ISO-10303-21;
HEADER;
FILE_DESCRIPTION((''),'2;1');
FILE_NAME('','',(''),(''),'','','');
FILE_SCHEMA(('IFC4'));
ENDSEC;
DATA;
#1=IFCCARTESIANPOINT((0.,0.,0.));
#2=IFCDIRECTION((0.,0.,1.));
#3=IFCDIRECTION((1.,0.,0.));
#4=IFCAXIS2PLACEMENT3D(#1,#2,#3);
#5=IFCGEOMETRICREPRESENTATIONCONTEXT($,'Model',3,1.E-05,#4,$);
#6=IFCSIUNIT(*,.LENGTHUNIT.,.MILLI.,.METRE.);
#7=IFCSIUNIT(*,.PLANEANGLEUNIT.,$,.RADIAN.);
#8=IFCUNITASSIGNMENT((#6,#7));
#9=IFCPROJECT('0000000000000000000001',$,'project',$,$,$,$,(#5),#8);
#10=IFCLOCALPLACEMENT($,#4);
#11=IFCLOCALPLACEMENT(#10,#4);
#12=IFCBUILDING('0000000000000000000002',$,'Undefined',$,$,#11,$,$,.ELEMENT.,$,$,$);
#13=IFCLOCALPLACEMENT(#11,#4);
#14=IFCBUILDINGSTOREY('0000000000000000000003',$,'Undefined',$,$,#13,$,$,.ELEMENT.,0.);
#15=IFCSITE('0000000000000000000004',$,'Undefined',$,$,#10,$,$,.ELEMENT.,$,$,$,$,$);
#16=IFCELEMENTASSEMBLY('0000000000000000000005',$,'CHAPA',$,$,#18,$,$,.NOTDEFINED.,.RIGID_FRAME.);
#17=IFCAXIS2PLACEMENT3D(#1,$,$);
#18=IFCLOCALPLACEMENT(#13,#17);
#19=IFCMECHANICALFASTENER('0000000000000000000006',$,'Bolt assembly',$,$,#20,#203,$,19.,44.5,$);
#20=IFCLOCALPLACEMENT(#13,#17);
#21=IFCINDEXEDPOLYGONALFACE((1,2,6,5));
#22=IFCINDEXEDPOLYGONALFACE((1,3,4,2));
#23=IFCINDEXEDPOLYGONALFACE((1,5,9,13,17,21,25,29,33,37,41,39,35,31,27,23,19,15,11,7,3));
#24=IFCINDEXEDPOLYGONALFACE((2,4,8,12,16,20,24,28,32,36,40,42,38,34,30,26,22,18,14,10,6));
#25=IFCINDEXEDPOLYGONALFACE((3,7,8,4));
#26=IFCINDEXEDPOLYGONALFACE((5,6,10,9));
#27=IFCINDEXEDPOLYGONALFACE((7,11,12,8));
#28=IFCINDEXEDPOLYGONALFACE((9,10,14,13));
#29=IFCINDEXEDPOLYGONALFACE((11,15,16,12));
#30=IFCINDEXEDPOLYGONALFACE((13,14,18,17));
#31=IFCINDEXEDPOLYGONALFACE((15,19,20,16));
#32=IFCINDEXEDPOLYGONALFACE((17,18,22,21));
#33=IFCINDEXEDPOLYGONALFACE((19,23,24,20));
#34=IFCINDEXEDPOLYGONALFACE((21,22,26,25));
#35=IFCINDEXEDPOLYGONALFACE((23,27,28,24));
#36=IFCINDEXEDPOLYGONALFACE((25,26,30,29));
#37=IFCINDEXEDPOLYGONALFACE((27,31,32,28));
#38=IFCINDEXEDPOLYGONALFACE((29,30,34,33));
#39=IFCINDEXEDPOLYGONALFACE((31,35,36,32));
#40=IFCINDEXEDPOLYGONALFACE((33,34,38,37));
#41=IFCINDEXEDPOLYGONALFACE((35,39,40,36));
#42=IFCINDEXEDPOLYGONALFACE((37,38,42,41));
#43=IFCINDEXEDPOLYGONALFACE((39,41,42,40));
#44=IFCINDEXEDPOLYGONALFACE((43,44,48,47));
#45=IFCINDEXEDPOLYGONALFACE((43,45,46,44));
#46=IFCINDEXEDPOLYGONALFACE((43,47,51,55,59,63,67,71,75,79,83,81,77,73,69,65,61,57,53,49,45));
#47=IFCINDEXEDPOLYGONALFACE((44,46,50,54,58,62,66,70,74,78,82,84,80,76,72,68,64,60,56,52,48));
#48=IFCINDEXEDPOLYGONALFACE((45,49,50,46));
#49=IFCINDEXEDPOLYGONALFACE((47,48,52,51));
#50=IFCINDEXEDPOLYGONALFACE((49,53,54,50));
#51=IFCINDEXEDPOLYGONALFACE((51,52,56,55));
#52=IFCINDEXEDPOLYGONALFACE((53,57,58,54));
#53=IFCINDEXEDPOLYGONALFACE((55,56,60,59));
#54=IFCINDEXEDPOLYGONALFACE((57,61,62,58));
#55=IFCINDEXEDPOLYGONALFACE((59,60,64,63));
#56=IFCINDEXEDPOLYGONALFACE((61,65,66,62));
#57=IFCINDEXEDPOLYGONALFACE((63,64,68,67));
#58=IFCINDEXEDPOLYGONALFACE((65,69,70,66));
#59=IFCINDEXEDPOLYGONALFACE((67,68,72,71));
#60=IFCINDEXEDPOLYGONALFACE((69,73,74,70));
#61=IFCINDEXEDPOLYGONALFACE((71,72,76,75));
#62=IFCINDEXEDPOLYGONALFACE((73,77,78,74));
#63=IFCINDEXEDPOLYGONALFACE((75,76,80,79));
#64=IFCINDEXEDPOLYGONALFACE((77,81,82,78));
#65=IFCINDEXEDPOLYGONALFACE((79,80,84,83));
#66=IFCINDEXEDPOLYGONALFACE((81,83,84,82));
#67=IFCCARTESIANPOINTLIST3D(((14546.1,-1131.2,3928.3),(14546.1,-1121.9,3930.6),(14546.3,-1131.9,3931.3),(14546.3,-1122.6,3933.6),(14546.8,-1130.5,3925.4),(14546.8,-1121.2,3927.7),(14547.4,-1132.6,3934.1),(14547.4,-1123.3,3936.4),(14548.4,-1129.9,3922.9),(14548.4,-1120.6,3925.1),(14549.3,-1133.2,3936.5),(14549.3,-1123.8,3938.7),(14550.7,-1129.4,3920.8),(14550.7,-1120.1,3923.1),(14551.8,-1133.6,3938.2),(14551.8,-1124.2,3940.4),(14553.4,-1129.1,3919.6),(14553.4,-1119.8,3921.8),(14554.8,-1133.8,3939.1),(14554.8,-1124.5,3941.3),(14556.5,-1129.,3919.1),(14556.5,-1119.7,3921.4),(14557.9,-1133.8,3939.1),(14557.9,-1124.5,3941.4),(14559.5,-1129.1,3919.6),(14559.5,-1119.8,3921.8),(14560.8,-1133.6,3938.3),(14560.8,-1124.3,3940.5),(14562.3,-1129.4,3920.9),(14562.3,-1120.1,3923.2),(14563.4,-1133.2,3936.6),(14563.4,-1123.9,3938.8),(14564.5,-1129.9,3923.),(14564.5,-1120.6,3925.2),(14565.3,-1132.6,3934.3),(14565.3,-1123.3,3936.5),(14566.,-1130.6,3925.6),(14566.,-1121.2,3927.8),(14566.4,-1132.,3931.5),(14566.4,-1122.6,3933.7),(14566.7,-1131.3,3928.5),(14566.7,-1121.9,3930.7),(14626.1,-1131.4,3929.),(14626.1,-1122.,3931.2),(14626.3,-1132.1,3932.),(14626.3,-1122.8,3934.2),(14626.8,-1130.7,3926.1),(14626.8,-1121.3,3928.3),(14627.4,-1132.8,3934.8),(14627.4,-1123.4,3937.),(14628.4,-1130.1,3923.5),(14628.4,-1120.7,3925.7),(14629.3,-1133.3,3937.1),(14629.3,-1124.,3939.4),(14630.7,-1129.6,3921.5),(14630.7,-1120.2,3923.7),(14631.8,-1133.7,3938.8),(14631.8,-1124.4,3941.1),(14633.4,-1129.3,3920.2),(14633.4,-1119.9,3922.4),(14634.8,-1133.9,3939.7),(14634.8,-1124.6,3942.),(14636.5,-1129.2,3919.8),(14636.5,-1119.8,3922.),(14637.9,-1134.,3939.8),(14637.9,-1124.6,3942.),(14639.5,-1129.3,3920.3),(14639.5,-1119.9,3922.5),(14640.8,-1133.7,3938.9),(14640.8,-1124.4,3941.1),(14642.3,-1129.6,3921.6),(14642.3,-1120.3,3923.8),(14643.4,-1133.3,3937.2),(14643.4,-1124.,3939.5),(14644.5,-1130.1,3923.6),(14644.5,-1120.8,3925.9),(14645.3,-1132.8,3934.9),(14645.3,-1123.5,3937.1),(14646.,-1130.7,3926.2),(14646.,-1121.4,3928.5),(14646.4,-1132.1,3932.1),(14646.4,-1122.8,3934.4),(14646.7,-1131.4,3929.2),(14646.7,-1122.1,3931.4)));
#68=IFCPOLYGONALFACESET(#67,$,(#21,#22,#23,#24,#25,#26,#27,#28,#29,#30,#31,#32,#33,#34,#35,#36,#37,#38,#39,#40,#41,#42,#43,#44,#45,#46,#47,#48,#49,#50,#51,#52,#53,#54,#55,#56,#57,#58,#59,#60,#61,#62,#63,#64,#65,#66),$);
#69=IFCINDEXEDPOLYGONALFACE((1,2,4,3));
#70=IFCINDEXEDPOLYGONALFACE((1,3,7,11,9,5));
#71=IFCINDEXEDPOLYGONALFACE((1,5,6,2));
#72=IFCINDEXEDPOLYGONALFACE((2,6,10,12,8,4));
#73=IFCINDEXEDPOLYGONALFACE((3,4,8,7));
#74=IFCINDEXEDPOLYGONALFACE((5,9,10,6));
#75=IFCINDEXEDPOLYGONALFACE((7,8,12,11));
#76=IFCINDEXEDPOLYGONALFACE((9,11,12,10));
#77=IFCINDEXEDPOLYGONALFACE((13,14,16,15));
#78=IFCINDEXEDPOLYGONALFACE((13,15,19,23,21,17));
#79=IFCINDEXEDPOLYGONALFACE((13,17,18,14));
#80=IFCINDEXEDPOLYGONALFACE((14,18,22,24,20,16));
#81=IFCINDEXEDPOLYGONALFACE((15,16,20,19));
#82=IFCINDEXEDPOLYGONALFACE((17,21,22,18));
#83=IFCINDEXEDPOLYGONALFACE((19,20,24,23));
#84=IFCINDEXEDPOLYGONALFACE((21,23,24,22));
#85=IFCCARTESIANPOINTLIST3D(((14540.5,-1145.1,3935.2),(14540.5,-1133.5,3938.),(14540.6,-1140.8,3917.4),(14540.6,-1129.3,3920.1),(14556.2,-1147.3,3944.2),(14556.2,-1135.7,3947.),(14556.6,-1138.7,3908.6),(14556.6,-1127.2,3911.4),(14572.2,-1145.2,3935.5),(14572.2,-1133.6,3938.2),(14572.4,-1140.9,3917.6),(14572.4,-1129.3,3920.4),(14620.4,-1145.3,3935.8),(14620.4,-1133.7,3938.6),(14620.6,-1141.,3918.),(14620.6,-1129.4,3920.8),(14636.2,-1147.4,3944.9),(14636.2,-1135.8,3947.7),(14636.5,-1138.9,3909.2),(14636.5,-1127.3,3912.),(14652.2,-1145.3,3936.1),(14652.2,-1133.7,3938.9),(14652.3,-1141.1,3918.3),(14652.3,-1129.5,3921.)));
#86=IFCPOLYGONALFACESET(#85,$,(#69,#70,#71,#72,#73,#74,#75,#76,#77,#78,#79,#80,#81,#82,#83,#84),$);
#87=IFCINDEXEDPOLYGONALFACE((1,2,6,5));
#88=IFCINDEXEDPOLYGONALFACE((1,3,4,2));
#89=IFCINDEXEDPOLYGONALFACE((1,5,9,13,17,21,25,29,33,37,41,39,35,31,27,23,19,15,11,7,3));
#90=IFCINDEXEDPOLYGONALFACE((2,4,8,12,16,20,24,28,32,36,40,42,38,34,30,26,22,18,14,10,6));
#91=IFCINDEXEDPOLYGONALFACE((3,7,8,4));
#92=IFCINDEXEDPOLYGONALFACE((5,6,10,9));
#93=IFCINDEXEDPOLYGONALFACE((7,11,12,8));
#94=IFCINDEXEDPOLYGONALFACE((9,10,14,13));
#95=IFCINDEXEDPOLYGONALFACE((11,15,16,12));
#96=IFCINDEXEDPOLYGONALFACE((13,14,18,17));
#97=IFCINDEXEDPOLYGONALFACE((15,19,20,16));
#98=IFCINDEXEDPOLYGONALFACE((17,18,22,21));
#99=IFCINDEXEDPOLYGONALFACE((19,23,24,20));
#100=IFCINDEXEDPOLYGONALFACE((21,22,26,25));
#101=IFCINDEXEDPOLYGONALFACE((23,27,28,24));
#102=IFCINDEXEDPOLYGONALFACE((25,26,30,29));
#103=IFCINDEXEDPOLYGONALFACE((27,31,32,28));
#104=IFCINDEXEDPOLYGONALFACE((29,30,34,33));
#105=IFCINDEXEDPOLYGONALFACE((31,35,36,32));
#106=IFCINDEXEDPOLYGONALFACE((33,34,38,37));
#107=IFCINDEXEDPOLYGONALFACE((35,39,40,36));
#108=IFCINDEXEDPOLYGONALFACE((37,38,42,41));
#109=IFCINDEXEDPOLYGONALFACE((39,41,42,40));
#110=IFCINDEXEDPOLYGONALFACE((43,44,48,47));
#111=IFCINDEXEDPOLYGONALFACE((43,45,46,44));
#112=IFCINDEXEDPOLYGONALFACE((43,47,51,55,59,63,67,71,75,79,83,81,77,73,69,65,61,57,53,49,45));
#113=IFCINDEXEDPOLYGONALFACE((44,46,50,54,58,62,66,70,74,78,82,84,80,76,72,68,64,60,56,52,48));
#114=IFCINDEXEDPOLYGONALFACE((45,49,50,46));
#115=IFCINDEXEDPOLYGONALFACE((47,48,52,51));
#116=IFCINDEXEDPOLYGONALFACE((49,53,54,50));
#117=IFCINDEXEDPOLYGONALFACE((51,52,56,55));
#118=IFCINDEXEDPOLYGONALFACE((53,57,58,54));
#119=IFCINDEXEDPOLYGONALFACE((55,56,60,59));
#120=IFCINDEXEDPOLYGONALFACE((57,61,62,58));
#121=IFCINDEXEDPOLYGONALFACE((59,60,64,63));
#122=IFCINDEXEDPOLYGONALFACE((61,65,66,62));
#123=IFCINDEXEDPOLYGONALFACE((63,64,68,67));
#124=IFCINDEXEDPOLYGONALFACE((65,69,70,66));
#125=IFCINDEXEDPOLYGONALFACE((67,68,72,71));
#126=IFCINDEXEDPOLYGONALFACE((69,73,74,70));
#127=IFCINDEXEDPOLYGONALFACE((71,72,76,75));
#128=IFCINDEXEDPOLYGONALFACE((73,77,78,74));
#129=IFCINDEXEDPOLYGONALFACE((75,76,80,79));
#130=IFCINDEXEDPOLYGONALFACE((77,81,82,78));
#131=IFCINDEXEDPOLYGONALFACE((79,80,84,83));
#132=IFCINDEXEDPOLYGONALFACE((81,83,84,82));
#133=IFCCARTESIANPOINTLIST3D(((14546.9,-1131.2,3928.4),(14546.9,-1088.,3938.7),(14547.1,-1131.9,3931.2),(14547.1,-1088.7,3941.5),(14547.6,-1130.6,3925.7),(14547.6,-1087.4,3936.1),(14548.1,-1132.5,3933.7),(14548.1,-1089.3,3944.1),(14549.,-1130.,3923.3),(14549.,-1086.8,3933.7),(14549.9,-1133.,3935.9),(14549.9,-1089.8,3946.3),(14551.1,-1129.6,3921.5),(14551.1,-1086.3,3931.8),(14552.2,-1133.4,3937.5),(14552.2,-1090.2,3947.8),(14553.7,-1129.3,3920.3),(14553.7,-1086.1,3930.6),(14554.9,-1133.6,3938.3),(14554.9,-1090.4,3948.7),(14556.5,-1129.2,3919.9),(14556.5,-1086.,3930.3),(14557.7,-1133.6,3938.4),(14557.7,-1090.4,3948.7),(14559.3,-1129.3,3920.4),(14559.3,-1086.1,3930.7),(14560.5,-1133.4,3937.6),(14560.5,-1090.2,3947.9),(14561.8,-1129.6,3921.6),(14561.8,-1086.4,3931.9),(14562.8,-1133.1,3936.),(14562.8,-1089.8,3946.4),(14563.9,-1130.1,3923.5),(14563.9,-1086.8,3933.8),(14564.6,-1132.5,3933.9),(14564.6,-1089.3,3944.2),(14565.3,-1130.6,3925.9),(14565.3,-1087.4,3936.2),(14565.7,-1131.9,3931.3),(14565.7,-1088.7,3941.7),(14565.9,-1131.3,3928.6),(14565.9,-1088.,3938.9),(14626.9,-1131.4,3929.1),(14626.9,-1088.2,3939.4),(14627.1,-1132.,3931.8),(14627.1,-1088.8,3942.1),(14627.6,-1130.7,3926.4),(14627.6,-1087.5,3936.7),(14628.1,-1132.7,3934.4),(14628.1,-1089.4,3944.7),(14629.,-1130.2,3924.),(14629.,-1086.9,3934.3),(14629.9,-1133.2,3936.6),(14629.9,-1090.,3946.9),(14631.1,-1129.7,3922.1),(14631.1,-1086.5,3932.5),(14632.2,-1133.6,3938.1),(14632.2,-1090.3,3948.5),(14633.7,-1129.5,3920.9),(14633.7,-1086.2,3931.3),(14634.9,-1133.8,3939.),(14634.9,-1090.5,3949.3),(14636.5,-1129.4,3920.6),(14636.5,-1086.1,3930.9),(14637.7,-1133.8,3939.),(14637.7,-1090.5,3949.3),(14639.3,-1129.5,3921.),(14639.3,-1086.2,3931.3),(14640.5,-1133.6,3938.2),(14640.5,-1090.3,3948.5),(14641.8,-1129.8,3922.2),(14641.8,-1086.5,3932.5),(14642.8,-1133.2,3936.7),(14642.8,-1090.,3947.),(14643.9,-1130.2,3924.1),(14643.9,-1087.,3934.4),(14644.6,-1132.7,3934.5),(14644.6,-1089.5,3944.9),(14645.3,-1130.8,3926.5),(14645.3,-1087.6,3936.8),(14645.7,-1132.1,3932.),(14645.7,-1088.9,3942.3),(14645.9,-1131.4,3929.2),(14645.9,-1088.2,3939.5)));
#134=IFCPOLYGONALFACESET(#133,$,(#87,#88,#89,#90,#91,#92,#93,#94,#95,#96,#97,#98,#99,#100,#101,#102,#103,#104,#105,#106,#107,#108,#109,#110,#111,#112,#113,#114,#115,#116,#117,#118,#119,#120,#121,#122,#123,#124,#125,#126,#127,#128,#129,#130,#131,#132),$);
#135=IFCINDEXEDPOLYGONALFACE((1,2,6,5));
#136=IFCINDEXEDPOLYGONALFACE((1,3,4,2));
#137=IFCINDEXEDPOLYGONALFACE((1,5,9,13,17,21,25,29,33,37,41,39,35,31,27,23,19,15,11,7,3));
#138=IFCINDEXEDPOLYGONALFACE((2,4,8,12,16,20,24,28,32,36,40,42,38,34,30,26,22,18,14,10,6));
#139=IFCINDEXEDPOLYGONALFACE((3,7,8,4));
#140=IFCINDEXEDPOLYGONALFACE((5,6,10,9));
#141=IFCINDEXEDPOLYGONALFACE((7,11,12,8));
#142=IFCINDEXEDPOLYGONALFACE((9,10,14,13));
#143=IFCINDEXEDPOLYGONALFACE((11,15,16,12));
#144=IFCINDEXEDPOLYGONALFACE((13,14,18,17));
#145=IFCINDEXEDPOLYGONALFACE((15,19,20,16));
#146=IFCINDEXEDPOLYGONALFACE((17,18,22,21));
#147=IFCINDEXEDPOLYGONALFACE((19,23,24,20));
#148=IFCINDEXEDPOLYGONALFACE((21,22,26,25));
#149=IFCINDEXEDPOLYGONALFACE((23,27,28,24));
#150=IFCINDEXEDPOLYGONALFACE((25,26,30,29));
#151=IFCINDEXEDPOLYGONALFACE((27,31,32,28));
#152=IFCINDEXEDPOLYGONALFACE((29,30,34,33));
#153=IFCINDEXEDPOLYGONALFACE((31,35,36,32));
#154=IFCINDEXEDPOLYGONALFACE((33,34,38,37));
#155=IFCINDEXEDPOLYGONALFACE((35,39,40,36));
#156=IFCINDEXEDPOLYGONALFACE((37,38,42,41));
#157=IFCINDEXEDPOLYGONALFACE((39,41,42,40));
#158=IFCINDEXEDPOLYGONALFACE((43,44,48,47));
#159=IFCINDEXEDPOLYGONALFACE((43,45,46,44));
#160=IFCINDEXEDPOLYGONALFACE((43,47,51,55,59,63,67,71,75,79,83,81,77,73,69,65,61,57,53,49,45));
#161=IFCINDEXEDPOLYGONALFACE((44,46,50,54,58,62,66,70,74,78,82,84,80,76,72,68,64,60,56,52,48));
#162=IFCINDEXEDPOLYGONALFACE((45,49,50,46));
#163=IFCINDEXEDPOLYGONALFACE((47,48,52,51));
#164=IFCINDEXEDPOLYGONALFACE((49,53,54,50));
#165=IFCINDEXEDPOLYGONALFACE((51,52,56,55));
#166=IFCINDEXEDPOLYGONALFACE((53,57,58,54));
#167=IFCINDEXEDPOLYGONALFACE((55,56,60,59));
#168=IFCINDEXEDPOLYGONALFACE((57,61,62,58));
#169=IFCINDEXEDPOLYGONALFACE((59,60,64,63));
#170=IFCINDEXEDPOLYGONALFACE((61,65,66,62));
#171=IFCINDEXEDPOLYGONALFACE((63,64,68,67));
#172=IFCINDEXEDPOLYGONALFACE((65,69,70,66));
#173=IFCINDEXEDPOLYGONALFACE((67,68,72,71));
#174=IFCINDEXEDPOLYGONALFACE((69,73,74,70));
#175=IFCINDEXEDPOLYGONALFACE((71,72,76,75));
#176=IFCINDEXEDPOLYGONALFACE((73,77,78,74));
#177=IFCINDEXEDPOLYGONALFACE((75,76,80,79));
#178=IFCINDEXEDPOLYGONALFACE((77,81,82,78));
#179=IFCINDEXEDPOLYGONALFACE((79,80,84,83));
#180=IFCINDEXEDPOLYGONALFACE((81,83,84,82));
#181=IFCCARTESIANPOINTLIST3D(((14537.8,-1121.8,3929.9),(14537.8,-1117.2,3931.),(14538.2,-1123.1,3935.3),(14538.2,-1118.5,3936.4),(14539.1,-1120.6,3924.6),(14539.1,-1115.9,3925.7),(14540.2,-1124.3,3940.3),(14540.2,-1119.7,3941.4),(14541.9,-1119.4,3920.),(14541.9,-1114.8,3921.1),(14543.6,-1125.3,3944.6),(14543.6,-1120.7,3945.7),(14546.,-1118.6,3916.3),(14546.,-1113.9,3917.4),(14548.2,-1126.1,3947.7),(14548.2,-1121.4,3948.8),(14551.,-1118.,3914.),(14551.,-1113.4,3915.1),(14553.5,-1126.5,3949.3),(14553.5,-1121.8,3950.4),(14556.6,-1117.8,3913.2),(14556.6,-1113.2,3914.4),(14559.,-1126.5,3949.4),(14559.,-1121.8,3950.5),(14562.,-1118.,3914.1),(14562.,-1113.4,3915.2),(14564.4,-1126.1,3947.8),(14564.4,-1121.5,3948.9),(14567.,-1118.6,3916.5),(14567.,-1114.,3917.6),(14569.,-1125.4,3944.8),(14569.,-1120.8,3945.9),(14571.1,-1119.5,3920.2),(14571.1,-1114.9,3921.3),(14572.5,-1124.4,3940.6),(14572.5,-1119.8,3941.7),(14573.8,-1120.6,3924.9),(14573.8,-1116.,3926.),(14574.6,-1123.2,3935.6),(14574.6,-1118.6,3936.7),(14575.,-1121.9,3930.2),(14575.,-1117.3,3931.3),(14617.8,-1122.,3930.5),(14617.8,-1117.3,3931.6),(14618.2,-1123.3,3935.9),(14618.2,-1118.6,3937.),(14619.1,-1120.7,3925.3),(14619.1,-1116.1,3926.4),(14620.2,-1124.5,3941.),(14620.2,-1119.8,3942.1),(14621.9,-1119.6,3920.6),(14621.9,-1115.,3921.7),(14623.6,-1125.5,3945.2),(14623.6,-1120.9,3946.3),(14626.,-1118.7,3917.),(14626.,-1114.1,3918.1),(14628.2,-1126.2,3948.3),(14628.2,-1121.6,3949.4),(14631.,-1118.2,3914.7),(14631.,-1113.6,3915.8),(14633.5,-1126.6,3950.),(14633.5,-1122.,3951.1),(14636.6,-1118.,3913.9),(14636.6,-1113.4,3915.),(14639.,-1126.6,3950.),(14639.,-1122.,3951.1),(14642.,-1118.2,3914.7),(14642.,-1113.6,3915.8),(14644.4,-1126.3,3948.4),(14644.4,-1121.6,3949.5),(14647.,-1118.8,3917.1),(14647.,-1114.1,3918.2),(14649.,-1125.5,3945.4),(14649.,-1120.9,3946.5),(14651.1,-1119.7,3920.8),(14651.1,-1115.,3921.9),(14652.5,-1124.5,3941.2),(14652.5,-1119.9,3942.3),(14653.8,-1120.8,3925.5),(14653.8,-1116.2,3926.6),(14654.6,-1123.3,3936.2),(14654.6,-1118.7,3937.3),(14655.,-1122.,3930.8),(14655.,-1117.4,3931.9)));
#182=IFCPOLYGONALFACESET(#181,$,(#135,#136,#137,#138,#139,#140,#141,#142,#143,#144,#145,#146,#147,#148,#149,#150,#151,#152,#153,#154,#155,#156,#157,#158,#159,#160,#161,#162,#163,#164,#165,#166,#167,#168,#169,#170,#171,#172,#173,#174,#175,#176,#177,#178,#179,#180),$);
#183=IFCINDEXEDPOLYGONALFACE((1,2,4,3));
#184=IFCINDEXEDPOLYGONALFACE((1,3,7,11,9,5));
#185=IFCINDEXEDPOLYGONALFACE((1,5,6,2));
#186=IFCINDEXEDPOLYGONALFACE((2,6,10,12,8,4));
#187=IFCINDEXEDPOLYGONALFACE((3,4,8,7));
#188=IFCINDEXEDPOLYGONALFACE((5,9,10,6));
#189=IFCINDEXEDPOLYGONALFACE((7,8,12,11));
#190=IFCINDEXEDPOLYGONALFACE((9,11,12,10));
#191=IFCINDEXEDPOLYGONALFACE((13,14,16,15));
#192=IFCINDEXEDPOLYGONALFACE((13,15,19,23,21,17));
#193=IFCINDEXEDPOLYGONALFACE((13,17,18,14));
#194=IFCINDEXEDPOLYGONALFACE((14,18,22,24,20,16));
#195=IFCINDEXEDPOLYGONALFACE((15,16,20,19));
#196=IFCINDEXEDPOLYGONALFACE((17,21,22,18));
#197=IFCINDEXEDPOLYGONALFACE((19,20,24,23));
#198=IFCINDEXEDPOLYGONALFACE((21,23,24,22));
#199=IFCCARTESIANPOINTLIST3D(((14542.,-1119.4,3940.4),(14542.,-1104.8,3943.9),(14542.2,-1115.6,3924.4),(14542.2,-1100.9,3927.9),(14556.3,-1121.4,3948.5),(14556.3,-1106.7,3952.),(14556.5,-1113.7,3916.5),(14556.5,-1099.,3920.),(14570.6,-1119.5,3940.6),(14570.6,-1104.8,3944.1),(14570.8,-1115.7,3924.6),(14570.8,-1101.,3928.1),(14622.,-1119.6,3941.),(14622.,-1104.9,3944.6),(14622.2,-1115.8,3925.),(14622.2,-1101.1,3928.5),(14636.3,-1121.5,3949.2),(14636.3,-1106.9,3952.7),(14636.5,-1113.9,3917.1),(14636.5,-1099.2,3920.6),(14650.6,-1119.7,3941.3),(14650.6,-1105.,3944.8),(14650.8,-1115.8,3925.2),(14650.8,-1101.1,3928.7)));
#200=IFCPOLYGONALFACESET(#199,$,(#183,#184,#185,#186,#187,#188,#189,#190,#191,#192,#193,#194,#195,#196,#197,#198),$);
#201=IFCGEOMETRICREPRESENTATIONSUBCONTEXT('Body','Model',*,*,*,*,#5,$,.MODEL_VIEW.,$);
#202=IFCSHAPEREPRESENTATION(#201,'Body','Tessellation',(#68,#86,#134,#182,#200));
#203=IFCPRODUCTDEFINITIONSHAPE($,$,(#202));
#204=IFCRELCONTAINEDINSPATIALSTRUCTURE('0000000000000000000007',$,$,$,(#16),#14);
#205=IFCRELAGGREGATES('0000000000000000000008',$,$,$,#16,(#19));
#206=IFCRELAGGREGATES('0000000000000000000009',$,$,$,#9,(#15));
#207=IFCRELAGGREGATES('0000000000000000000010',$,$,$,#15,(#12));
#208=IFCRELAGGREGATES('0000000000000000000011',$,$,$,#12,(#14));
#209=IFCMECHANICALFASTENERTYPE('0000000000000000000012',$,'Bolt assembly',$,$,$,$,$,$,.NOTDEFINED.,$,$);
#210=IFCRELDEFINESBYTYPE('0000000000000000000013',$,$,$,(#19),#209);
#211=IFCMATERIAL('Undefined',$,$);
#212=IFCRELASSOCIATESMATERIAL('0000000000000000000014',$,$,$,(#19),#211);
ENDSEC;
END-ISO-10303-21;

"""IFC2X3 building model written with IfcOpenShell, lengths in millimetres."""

from ifc_helpers import new_model, si_unit, frame, origin_with_axes, origin_2d_with_axis, place, context, subcontext, project, spatial, polyline, circle, outline, extrude, source, transform, mapped, material, type_object, element, aggregate, save


model = new_model("IFC2X3")

# Units and contexts
model_context = context("Model", 3, precision=1e-05, world=origin_with_axes())
body_context = subcontext(model_context, "Body", "Model", "MODEL_VIEW")
ifc_project = project(units=[si_unit("LENGTHUNIT", "METRE", prefix="MILLI"), si_unit("PLANEANGLEUNIT", "RADIAN")], contexts=[model_context])

# Site, building, storey
site_placement = place(None, origin_with_axes())
site = spatial("IfcSite", under=ifc_project, at=site_placement, Name="Undefined", CompositionType="ELEMENT")
building_placement = place(site_placement, origin_with_axes())
building = spatial("IfcBuilding", under=site, at=building_placement, Name="Undefined", CompositionType="ELEMENT")
storey_placement = place(building_placement, origin_with_axes())
storey = spatial("IfcBuildingStorey", under=building, at=storey_placement, Name="Undefined", CompositionType="ELEMENT", Elevation=0.0)

# Element assembly
assembly_1_placement = place(storey_placement, origin_with_axes())
assembly_1 = element("IfcElementAssembly", 1, at=assembly_1_placement, inside=storey, Name="CHAPA", AssemblyPlace="NOTDEFINED", PredefinedType="RIGID_FRAME")

# Shared definitions
ifc_material_1 = material(Name="Undefined")
mechanical_fastener_type = type_object("IfcMechanicalFastenerType", Name="Bolt assembly")

# Mechanical fastener
shared_shape_1 = source(origin_with_axes(), body_context, "Body", "SweptSolid", [
    extrude(circle(Radius=10.3, at=origin_2d_with_axis()), frame((0.0, 0.0, 0.0), z_axis=(0.0, 1.0, 0.0), x_axis=(1.0, 0.0, 0.0)), (0.0, 0.0, 1.0), 9.6),
    extrude(outline(polyline([(18.3, 0.0), (9.2, 15.9), (-9.2, 15.9), (-18.3, 0.0), (-9.2, -15.9), (9.2, -15.9), (18.3, 0.0)])), frame((0.0, -11.9, 0.0), z_axis=(0.0, 1.0, 0.0), x_axis=(1.0, 0.0, 0.0)), (0.0, 0.0, 1.0), 11.9),
    extrude(circle(Radius=9.5, at=origin_2d_with_axis()), frame((0.0, 0.0, 0.0), z_axis=(0.0, 1.0, 0.0), x_axis=(1.0, 0.0, 0.0)), (0.0, 0.0, 1.0), 44.5),
    extrude(circle(Radius=18.7, at=origin_2d_with_axis()), frame((0.0, 9.5, 0.0), z_axis=(0.0, 1.0, 0.0), x_axis=(1.0, 0.0, 0.0)), (0.0, 0.0, 1.0), 4.8),
    extrude(outline(polyline([(16.5, 0.0), (8.2, 14.3), (-8.2, 14.3), (-16.5, 0.0), (-8.2, -14.3), (8.2, -14.3), (16.5, 0.0)])), frame((0.0, 14.3, 0.0), z_axis=(0.0, 1.0, 0.0), x_axis=(1.0, 0.0, 0.0)), (0.0, 0.0, 1.0), 15.1),
])
mechanical_fastener_1_placement = place(assembly_1_placement, frame((14596.4, -1131.5, 3929.5), z_axis=(0.999966, -0.001918, 0.008027), x_axis=(0.008253, 0.23249, -0.972564)))
mechanical_fastener_1 = element("IfcMechanicalFastener", 2, at=mechanical_fastener_1_placement, type_object=mechanical_fastener_type, material=ifc_material_1, Name="Bolt assembly", NominalDiameter=19.0, NominalLength=44.5, context=body_context, shape_type="MappedRepresentation", body=[
    mapped(shared_shape_1, transform((0.0, 0.0, -40.0))),
    mapped(shared_shape_1, transform((0.0, 0.0, 40.0))),
])
aggregate(assembly_1, [mechanical_fastener_1])

save(model, "model.ifc")
